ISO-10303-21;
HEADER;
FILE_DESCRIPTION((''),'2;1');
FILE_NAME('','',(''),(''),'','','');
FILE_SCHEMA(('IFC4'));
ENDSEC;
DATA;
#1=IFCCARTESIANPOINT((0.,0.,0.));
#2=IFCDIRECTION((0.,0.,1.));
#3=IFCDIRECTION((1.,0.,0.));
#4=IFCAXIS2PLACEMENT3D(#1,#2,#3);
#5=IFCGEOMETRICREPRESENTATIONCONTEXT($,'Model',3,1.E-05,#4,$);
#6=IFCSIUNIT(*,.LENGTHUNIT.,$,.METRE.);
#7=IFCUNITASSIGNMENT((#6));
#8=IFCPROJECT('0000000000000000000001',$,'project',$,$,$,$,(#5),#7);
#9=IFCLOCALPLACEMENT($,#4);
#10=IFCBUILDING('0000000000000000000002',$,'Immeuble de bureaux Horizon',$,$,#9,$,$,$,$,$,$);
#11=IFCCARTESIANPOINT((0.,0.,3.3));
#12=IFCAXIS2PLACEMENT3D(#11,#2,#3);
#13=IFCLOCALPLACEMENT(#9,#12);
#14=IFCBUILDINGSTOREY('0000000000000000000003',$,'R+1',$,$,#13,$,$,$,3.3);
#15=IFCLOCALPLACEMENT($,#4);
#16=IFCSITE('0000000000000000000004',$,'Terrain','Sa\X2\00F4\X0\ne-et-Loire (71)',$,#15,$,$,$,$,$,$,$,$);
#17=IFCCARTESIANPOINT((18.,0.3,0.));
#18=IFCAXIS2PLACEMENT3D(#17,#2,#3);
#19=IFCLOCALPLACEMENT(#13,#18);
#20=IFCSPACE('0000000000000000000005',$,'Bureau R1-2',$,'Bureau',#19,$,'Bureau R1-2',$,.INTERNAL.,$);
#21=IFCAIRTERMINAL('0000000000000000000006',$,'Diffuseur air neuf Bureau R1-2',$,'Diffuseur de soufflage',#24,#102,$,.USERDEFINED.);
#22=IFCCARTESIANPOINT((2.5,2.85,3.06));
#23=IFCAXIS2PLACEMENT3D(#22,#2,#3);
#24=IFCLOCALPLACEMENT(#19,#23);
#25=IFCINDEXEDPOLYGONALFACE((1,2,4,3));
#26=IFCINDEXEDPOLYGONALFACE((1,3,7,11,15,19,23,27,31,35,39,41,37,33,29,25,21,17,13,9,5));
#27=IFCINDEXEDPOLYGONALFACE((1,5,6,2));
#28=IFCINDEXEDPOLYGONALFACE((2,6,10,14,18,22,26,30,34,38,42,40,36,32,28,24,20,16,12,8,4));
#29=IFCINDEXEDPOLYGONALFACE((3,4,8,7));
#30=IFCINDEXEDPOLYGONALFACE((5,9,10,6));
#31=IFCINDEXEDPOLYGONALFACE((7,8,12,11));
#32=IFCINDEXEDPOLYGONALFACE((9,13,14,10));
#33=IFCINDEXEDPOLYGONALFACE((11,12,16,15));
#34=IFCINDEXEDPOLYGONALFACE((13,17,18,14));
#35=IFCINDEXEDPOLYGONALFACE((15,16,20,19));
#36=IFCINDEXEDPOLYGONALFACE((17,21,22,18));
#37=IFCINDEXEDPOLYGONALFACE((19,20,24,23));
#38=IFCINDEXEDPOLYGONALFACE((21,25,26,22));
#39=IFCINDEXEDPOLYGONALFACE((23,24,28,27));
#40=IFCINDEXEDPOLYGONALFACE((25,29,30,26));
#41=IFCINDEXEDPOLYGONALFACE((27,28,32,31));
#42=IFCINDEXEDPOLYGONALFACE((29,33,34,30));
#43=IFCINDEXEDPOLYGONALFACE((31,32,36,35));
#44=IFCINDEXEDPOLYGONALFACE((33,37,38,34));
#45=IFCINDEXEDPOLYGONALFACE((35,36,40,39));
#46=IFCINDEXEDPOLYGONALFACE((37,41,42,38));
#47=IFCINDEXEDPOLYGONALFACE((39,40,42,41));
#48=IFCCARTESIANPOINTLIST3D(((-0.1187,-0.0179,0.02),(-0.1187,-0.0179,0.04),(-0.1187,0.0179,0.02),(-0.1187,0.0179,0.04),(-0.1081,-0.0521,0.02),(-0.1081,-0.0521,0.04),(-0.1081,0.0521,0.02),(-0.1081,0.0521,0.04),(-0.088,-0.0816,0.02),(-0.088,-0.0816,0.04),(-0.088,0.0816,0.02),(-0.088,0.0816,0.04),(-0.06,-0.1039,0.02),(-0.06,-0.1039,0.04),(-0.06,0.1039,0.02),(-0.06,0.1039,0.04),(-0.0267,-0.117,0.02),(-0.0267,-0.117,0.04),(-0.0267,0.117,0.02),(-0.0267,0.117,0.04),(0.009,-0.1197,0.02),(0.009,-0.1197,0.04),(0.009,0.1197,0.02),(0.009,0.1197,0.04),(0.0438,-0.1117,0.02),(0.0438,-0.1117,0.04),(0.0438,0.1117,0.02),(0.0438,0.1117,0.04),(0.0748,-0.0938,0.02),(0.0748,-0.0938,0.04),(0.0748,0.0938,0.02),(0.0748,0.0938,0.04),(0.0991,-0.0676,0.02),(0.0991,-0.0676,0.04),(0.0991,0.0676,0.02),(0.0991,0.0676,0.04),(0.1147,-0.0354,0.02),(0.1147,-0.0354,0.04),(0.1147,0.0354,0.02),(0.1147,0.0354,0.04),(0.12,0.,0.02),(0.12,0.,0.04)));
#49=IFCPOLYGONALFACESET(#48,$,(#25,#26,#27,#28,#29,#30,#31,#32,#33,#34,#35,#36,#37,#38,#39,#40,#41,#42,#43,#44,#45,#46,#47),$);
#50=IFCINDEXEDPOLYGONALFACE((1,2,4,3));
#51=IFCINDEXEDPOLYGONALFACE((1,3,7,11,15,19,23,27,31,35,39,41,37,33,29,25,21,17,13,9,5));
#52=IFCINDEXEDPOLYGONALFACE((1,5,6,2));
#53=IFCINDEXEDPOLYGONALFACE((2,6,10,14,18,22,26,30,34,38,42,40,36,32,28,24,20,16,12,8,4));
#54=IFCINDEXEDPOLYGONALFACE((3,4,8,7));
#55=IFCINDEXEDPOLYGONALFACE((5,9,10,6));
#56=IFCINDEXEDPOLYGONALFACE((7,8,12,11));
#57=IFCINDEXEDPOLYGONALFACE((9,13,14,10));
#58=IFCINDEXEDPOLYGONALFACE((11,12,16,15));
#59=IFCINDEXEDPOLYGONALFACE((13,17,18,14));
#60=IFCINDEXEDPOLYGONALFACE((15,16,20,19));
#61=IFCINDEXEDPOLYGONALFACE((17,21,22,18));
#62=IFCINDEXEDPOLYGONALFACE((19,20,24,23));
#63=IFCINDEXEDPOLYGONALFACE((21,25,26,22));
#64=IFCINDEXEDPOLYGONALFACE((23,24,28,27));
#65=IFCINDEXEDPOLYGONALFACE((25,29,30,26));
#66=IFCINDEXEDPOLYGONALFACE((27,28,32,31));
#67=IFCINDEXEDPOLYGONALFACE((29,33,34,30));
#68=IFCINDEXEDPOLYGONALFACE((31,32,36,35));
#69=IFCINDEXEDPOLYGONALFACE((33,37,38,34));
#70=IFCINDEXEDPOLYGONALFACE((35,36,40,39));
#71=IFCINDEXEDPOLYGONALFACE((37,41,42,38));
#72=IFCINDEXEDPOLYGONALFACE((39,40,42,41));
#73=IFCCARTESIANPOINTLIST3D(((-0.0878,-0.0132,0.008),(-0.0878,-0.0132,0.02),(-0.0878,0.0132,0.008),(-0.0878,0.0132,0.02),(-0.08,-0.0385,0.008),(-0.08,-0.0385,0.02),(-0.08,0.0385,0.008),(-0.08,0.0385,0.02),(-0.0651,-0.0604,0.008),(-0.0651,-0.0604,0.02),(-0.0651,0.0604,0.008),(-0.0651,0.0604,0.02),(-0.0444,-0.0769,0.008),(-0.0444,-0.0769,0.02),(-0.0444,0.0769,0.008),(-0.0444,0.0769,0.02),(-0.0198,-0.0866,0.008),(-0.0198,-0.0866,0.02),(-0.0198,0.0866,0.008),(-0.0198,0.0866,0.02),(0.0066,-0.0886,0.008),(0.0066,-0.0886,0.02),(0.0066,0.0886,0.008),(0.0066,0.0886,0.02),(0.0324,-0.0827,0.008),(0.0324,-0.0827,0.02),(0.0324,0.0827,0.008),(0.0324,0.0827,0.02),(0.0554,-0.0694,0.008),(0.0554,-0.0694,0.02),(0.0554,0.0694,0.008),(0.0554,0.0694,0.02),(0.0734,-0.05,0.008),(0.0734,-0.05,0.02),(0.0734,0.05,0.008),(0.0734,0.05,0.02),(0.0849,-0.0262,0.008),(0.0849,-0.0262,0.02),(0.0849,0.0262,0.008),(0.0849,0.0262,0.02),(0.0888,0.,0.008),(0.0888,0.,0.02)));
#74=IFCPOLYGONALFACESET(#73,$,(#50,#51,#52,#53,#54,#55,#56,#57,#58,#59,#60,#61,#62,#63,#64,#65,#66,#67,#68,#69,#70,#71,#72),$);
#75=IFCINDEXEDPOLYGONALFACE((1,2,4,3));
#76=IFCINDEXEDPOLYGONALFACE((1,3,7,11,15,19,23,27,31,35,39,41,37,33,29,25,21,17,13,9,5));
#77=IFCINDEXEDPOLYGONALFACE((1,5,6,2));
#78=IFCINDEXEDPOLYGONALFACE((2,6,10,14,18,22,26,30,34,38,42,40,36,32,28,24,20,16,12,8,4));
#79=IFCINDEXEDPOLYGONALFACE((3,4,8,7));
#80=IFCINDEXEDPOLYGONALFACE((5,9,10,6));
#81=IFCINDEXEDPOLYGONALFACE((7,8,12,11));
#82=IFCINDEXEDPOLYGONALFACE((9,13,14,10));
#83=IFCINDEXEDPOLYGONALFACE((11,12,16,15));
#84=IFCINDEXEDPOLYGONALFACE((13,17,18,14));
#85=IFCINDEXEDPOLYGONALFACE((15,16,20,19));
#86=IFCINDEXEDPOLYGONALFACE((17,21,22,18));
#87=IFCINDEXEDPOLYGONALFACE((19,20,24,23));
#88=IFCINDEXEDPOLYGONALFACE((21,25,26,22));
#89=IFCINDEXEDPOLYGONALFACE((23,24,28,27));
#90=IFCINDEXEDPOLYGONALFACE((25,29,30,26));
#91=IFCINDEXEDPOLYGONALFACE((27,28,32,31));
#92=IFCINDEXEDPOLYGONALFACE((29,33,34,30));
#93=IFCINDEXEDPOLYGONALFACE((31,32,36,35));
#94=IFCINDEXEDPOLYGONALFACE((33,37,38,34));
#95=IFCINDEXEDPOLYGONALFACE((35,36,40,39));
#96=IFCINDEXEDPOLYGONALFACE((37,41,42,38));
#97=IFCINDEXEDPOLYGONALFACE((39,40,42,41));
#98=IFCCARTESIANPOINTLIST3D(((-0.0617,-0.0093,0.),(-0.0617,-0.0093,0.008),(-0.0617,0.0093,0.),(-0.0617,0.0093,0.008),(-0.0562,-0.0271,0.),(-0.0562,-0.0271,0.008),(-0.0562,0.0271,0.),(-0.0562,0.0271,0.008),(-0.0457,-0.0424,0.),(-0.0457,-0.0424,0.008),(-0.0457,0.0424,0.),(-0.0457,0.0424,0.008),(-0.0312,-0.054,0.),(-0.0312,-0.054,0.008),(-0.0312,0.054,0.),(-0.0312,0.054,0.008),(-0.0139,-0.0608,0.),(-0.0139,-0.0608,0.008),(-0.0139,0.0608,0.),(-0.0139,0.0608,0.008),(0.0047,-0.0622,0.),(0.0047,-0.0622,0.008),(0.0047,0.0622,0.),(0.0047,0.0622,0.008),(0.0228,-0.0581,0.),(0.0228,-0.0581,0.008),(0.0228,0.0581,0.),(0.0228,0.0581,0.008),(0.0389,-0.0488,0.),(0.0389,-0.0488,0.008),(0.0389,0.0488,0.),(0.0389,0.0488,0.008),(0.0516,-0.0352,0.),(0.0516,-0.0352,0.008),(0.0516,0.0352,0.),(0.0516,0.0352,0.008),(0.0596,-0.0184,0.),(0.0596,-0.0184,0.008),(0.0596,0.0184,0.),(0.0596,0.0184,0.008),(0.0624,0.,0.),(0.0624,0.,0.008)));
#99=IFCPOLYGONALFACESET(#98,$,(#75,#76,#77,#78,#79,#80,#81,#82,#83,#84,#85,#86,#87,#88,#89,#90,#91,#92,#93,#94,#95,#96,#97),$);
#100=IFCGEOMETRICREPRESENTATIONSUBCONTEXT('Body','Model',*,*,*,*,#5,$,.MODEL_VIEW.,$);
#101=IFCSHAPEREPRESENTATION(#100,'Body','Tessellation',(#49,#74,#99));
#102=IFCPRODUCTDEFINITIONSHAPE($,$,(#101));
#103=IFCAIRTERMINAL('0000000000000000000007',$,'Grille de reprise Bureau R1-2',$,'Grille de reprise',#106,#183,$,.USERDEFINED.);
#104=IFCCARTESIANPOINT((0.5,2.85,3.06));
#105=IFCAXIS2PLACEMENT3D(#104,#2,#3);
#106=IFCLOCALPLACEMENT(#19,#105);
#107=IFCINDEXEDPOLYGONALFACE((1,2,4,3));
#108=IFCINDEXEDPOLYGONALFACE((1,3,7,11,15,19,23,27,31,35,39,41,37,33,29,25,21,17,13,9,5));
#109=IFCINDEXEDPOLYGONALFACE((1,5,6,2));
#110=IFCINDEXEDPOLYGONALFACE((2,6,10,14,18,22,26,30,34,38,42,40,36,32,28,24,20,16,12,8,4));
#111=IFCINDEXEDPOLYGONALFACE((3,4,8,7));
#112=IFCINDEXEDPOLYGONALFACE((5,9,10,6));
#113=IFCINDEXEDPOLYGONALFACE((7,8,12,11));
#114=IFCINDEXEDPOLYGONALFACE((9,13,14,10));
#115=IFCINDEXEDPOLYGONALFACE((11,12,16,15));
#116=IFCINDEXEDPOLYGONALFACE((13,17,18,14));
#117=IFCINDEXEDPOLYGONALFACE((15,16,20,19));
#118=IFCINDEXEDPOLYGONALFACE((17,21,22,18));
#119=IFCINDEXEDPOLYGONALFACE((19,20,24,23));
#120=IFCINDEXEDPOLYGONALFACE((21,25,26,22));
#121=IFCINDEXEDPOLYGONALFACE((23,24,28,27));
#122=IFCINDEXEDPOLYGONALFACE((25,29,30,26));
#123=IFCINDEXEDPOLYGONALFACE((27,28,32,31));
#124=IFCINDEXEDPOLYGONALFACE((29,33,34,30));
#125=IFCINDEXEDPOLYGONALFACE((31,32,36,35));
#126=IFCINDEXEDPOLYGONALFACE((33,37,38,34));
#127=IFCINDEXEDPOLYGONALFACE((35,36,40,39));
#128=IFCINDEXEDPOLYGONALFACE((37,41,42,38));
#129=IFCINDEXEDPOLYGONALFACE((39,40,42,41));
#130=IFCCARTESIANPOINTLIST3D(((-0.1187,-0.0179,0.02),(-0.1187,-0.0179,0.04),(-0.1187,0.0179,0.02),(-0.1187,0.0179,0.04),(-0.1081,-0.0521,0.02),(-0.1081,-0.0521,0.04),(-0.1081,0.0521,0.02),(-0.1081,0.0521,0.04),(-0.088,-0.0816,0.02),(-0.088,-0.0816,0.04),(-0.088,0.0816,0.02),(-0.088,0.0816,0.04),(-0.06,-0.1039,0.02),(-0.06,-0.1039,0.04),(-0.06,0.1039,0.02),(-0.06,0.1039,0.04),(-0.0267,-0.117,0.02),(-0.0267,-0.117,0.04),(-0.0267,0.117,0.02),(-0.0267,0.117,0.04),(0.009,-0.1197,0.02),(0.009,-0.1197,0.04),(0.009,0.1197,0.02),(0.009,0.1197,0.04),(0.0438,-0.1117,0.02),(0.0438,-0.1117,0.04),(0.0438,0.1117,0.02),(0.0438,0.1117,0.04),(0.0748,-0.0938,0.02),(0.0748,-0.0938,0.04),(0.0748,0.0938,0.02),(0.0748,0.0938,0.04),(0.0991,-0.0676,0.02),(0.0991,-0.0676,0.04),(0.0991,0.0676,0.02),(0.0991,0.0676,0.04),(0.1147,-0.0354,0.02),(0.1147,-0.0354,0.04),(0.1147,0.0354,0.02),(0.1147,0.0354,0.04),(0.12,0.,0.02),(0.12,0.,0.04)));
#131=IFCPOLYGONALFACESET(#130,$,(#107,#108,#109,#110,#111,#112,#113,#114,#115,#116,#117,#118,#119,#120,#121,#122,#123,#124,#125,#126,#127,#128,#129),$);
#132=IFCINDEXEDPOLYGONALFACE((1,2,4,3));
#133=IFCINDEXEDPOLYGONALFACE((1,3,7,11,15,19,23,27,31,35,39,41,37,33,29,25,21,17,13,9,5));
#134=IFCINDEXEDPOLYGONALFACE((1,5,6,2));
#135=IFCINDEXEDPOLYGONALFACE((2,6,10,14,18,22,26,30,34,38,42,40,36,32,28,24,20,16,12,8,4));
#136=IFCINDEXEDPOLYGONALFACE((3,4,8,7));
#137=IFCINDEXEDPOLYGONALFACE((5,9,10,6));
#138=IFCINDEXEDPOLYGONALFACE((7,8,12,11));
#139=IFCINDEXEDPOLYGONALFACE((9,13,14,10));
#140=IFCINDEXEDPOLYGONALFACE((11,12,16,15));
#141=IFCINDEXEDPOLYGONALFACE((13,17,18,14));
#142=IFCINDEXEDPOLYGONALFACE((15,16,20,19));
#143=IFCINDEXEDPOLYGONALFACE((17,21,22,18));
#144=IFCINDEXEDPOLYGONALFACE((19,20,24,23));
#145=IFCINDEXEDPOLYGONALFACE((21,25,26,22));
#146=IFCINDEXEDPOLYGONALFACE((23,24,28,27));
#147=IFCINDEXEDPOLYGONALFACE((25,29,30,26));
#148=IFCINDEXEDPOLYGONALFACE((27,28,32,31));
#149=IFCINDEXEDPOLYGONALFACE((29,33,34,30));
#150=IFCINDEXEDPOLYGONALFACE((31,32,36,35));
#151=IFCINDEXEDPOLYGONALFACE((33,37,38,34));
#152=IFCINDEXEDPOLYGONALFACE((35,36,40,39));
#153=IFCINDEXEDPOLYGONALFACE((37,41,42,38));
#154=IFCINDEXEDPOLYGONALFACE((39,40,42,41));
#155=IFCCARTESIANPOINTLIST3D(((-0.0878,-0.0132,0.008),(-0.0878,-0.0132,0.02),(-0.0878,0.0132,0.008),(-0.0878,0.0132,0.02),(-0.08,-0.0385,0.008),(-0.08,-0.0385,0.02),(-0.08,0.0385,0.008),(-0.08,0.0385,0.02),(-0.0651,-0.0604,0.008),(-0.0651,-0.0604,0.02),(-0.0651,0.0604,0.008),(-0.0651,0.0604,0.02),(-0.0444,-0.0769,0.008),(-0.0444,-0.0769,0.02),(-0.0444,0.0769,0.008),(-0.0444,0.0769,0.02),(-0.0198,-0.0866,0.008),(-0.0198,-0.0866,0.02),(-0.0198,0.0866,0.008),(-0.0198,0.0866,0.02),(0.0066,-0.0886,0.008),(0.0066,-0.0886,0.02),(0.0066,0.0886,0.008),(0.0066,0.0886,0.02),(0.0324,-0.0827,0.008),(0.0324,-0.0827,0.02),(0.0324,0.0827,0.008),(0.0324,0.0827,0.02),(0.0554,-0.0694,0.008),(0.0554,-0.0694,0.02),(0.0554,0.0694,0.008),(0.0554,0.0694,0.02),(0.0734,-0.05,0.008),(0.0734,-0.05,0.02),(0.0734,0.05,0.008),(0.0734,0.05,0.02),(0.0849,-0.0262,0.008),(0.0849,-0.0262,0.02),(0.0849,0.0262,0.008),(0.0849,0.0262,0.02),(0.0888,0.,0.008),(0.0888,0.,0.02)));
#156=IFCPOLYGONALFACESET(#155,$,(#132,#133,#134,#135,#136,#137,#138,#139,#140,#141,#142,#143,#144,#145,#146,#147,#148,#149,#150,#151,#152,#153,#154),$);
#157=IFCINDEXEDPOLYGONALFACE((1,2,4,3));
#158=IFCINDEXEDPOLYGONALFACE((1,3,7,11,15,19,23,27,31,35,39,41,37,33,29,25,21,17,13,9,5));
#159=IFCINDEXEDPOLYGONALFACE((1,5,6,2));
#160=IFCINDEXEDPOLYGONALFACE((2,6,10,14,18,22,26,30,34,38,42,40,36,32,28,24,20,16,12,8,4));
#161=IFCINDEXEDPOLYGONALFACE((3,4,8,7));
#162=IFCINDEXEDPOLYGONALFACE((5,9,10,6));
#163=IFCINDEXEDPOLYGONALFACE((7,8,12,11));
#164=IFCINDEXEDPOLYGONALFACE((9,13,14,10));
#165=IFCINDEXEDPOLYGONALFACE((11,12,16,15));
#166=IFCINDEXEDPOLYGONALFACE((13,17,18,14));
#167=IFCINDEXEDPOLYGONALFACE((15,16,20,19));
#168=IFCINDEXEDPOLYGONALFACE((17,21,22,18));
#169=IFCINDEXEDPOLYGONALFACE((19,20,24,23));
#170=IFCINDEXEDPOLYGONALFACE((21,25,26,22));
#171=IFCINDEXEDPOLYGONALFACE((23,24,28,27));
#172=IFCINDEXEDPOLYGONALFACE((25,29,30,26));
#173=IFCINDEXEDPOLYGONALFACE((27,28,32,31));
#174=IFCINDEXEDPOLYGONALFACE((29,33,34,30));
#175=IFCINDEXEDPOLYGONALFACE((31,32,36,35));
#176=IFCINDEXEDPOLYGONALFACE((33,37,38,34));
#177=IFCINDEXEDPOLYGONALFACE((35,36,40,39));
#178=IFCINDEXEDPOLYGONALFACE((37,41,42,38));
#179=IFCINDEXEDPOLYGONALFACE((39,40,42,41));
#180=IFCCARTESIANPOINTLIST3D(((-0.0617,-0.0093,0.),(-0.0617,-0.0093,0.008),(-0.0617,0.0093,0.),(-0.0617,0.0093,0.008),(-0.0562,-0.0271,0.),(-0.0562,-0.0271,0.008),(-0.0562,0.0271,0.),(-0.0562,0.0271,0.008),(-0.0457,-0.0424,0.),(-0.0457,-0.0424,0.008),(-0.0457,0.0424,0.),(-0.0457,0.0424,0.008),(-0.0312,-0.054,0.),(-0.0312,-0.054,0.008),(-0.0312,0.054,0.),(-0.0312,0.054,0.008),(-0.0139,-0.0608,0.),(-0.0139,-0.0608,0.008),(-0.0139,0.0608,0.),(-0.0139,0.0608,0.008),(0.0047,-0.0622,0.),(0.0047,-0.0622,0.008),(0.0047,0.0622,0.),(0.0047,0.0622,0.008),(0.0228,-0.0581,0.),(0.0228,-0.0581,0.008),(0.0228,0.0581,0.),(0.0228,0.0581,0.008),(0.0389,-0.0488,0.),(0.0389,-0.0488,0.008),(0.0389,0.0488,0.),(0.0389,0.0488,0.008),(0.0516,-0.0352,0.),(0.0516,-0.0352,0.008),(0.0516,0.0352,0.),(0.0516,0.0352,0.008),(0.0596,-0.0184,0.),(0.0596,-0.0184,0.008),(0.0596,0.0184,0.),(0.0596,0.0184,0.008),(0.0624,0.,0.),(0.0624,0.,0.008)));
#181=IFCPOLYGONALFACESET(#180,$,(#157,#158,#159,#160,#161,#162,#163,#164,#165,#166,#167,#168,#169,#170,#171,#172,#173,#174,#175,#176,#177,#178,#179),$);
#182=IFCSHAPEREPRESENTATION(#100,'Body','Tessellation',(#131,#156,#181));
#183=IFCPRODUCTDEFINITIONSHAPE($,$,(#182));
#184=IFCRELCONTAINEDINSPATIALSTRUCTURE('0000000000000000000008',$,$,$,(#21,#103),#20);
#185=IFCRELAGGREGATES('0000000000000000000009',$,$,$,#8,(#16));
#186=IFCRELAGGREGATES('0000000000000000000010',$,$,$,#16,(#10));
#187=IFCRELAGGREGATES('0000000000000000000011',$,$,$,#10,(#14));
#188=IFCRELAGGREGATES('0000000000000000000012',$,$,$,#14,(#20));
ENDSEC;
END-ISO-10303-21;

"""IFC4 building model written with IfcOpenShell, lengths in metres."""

from ifc_helpers import new_model, si_unit, frame, origin_with_axes, place, context, subcontext, project, spatial, circle, extrude, element, save


model = new_model("IFC4")

# Units and contexts
model_context = context("Model", 3, precision=1e-05, world=origin_with_axes())
body_context = subcontext(model_context, "Body", "Model", "MODEL_VIEW")
ifc_project = project(units=[si_unit("LENGTHUNIT", "METRE")], contexts=[model_context])

# Site, building, storey
site_placement = place(None, origin_with_axes())
site = spatial("IfcSite", under=ifc_project, at=site_placement, Name="Terrain", Description="Saône-et-Loire (71)")
building_placement = place(None, origin_with_axes())
building = spatial("IfcBuilding", under=site, at=building_placement, Name="Immeuble de bureaux Horizon")
storey_placement = place(building_placement, frame((0.0, 0.0, 3.3), z_axis=(0.0, 0.0, 1.0), x_axis=(1.0, 0.0, 0.0)))
storey = spatial("IfcBuildingStorey", under=building, at=storey_placement, Name="R+1", Elevation=3.3)

# Shared definitions
space_1_placement = place(storey_placement, frame((18.0, 0.3, 0.0), z_axis=(0.0, 0.0, 1.0), x_axis=(1.0, 0.0, 0.0)))
space_1 = spatial("IfcSpace", under=storey, at=space_1_placement, Name="Bureau R1-2", ObjectType="Bureau", LongName="Bureau R1-2", PredefinedType="INTERNAL")

# Air terminal
air_terminal_1_placement = place(space_1_placement, frame((2.5, 2.85, 3.06), z_axis=(0.0, 0.0, 1.0), x_axis=(1.0, 0.0, 0.0)))
element("IfcAirTerminal", 1, at=air_terminal_1_placement, inside=space_1, Name="Diffuseur air neuf Bureau R1-2", ObjectType="Diffuseur de soufflage", PredefinedType="USERDEFINED", context=body_context, shape_type="SweptSolid", body=[
    extrude(circle(Radius=0.12), frame((0.0, 0.0, 0.02), z_axis=(0.0, 0.0, 1.0), x_axis=(1.0, 0.0, 0.0)), (0.0, 0.0, 1.0), 0.02),
    extrude(circle(Radius=0.0888), frame((0.0, 0.0, 0.008), z_axis=(0.0, 0.0, 1.0), x_axis=(1.0, 0.0, 0.0)), (0.0, 0.0, 1.0), 0.012),
    extrude(circle(Radius=0.0624), origin_with_axes(), (0.0, 0.0, 1.0), 0.008),
])

# Air terminal
air_terminal_2_placement = place(space_1_placement, frame((0.5, 2.85, 3.06), z_axis=(0.0, 0.0, 1.0), x_axis=(1.0, 0.0, 0.0)))
element("IfcAirTerminal", 2, at=air_terminal_2_placement, inside=space_1, Name="Grille de reprise Bureau R1-2", ObjectType="Grille de reprise", PredefinedType="USERDEFINED", context=body_context, shape_type="SweptSolid", body=[
    extrude(circle(Radius=0.12), frame((0.0, 0.0, 0.02), z_axis=(0.0, 0.0, 1.0), x_axis=(1.0, 0.0, 0.0)), (0.0, 0.0, 1.0), 0.02),
    extrude(circle(Radius=0.0888), frame((0.0, 0.0, 0.008), z_axis=(0.0, 0.0, 1.0), x_axis=(1.0, 0.0, 0.0)), (0.0, 0.0, 1.0), 0.012),
    extrude(circle(Radius=0.0624), origin_with_axes(), (0.0, 0.0, 1.0), 0.008),
])

save(model, "model.ifc")
